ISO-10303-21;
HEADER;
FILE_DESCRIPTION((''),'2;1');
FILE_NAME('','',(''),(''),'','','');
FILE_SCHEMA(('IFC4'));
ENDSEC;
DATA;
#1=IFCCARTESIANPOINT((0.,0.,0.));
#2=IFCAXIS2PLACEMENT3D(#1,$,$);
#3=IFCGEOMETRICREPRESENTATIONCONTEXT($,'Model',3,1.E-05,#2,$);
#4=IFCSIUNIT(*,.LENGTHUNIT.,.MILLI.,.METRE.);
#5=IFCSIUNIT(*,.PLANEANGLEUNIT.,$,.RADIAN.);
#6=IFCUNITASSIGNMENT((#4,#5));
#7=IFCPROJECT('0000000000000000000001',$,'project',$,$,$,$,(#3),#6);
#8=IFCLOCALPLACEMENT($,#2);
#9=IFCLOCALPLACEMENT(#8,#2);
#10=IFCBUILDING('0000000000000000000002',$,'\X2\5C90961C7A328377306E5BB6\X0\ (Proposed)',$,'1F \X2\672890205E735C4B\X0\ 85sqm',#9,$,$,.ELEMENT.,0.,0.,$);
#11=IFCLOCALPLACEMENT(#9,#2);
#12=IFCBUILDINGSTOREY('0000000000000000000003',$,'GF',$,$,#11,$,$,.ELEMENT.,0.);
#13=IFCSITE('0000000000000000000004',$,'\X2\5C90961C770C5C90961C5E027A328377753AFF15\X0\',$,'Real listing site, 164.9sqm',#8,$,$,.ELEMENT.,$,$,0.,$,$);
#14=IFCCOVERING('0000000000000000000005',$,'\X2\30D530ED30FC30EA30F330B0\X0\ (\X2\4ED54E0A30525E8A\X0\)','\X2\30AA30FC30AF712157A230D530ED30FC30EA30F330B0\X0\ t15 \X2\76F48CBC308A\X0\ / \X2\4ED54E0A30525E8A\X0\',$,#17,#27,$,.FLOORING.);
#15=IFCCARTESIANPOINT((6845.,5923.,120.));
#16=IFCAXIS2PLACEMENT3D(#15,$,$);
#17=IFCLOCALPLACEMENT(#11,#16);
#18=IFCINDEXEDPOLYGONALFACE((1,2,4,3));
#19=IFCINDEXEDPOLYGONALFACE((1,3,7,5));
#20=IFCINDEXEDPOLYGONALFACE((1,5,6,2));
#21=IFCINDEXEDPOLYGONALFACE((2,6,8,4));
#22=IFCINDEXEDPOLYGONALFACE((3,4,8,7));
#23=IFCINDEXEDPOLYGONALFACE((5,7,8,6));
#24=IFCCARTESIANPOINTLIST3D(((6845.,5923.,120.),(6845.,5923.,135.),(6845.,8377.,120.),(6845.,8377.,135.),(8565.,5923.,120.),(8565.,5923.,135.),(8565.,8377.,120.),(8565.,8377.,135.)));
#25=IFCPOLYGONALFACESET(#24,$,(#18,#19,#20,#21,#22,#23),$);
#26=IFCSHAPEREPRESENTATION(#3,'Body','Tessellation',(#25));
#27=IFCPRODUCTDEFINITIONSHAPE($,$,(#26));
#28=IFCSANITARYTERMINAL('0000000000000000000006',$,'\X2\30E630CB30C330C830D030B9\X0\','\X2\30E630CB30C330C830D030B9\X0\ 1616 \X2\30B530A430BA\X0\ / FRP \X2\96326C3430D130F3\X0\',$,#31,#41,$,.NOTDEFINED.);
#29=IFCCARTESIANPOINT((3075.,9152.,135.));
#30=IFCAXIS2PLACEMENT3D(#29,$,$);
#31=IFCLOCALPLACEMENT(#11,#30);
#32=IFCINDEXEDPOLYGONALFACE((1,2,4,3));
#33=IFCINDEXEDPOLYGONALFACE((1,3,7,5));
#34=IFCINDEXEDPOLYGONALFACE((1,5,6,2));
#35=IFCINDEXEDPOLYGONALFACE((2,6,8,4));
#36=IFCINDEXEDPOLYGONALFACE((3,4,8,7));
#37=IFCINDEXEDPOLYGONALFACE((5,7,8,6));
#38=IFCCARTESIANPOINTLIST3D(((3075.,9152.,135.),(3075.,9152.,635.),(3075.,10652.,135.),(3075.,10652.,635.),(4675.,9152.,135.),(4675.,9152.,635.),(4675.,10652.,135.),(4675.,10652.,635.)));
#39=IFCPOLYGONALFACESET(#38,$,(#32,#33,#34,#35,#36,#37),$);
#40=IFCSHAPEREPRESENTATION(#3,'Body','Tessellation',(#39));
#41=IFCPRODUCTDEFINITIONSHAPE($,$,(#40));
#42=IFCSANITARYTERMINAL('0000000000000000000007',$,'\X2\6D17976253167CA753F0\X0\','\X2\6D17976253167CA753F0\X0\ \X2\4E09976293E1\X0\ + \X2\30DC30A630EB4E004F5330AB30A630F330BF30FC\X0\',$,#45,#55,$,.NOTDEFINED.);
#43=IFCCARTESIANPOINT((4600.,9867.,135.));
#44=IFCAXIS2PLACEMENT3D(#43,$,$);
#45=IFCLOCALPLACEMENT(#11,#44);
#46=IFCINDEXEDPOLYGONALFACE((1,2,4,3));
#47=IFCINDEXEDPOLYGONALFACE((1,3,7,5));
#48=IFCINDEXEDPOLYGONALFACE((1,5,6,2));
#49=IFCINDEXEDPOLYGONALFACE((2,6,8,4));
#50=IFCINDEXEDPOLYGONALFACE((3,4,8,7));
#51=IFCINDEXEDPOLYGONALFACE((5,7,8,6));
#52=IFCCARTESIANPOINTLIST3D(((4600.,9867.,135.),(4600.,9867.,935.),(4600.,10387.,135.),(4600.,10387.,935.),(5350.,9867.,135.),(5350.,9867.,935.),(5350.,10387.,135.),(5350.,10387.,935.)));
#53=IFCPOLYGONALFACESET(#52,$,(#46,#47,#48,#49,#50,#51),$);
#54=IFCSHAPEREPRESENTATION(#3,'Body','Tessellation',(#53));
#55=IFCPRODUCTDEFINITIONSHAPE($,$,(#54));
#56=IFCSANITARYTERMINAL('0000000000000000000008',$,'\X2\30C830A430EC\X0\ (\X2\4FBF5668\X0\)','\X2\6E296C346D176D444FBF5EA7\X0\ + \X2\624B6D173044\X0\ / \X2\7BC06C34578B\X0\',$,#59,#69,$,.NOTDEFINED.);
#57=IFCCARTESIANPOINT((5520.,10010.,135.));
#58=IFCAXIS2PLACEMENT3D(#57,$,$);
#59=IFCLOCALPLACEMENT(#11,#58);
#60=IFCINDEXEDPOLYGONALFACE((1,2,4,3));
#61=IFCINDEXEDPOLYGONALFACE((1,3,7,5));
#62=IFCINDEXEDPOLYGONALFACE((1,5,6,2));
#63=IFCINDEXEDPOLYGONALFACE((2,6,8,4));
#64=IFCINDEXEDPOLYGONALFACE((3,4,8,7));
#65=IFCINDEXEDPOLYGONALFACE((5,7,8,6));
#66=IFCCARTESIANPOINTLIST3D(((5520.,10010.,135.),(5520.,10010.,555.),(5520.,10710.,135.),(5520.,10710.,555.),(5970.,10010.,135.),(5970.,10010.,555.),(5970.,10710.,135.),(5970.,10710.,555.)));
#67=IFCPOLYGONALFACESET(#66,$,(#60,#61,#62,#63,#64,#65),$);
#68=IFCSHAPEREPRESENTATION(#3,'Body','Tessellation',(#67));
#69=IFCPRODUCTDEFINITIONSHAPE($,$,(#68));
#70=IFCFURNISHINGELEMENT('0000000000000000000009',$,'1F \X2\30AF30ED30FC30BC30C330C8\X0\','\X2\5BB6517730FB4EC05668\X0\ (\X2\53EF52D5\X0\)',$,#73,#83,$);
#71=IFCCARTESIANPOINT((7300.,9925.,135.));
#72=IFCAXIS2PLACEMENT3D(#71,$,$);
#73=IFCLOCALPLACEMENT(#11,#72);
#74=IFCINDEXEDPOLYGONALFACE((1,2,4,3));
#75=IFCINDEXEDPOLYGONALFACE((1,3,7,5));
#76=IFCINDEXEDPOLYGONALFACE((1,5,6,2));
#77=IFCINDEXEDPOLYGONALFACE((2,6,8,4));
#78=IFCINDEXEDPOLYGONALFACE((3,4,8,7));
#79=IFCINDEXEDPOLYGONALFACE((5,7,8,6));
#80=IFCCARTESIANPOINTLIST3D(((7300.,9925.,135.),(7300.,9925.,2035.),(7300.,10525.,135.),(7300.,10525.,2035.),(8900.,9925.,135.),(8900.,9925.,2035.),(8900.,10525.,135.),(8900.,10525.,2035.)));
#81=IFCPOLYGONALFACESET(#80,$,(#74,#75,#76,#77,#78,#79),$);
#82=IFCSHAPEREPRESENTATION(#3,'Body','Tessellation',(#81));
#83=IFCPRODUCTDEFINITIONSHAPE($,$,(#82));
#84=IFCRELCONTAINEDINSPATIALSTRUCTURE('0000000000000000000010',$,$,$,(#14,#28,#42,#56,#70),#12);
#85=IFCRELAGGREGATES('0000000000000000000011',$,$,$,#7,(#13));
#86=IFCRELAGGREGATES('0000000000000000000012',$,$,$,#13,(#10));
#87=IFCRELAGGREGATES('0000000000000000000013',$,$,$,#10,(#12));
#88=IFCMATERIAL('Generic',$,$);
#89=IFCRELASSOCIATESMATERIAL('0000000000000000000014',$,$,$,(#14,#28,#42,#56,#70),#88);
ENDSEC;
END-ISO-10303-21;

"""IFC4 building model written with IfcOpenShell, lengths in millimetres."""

from ifc_helpers import new_model, si_unit, frame, frame_2d, origin, place, context, project, spatial, rectangle, extrude, material, element, save


model = new_model("IFC4")

# Units and contexts
model_context = context("Model", 3, precision=1e-05, world=origin())
ifc_project = project(units=[si_unit("LENGTHUNIT", "METRE", prefix="MILLI"), si_unit("PLANEANGLEUNIT", "RADIAN")], contexts=[model_context])

# Site, building, storey
site_placement = place(None, origin())
site = spatial("IfcSite", under=ifc_project, at=site_placement, Name="岐阜県岐阜市稲荷町５", ObjectType="Real listing site, 164.9sqm", CompositionType="ELEMENT", RefElevation=0.0)
building_placement = place(site_placement, origin())
building = spatial("IfcBuilding", under=site, at=building_placement, Name="岐阜稲荷の家 (Proposed)", ObjectType="1F 木造平屋 85sqm", CompositionType="ELEMENT", ElevationOfRefHeight=0.0, ElevationOfTerrain=0.0)
storey_placement = place(building_placement, origin())
storey = spatial("IfcBuildingStorey", under=building, at=storey_placement, Name="GF", CompositionType="ELEMENT", Elevation=0.0)

# Covering
ifc_material_1 = material(Name="Generic")
covering_1_placement = place(storey_placement, frame((6845.0, 5923.0, 120.0)))
element("IfcCovering", 1, at=covering_1_placement, inside=storey, material=ifc_material_1, Name="フローリング (仕上げ床)", Description="オーク無垢フローリング t15 直貼り / 仕上げ床", PredefinedType="FLOORING", context=model_context, shape_type="SweptSolid", body=[
    extrude(rectangle(XDim=1720.0, YDim=2454.0, at=frame_2d((860.0, 1227.0))), frame((6845.0, 5923.0, 120.0)), (0.0, 0.0, 1.0), 15.0),
])

# Sanitary terminals
sanitary_terminal_1_placement = place(storey_placement, frame((3075.0, 9152.0, 135.0)))
element("IfcSanitaryTerminal", 2, at=sanitary_terminal_1_placement, inside=storey, material=ifc_material_1, Name="ユニットバス", Description="ユニットバス 1616 サイズ / FRP 防水パン", PredefinedType="NOTDEFINED", context=model_context, shape_type="SweptSolid", body=[
    extrude(rectangle(XDim=1600.0, YDim=1500.0, at=frame_2d((800.0, 750.0))), frame((3075.0, 9152.0, 135.0)), (0.0, 0.0, 1.0), 500.0),
])
sanitary_terminal_2_placement = place(storey_placement, frame((4600.0, 9867.0, 135.0)))
element("IfcSanitaryTerminal", 3, at=sanitary_terminal_2_placement, inside=storey, material=ifc_material_1, Name="洗面化粧台", Description="洗面化粧台 三面鏡 + ボウル一体カウンター", PredefinedType="NOTDEFINED", context=model_context, shape_type="SweptSolid", body=[
    extrude(rectangle(XDim=750.0, YDim=520.0, at=frame_2d((375.0, 260.0))), frame((4600.0, 9867.0, 135.0)), (0.0, 0.0, 1.0), 800.0),
])
sanitary_terminal_3_placement = place(storey_placement, frame((5520.0, 10010.0, 135.0)))
element("IfcSanitaryTerminal", 4, at=sanitary_terminal_3_placement, inside=storey, material=ifc_material_1, Name="トイレ (便器)", Description="温水洗浄便座 + 手洗い / 節水型", PredefinedType="NOTDEFINED", context=model_context, shape_type="SweptSolid", body=[
    extrude(rectangle(XDim=450.0, YDim=700.0, at=frame_2d((225.0, 350.0))), frame((5520.0, 10010.0, 135.0)), (0.0, 0.0, 1.0), 420.0),
])

# Furnishing element
furnishing_placement = place(storey_placement, frame((7300.0, 9925.0, 135.0)))
element("IfcFurnishingElement", 5, at=furnishing_placement, inside=storey, material=ifc_material_1, Name="1F クローゼット", Description="家具・什器 (可動)", context=model_context, shape_type="SweptSolid", body=[
    extrude(rectangle(XDim=1600.0, YDim=600.0, at=frame_2d((800.0, 300.0))), frame((7300.0, 9925.0, 135.0)), (0.0, 0.0, 1.0), 1900.0),
])

save(model, "model.ifc")
